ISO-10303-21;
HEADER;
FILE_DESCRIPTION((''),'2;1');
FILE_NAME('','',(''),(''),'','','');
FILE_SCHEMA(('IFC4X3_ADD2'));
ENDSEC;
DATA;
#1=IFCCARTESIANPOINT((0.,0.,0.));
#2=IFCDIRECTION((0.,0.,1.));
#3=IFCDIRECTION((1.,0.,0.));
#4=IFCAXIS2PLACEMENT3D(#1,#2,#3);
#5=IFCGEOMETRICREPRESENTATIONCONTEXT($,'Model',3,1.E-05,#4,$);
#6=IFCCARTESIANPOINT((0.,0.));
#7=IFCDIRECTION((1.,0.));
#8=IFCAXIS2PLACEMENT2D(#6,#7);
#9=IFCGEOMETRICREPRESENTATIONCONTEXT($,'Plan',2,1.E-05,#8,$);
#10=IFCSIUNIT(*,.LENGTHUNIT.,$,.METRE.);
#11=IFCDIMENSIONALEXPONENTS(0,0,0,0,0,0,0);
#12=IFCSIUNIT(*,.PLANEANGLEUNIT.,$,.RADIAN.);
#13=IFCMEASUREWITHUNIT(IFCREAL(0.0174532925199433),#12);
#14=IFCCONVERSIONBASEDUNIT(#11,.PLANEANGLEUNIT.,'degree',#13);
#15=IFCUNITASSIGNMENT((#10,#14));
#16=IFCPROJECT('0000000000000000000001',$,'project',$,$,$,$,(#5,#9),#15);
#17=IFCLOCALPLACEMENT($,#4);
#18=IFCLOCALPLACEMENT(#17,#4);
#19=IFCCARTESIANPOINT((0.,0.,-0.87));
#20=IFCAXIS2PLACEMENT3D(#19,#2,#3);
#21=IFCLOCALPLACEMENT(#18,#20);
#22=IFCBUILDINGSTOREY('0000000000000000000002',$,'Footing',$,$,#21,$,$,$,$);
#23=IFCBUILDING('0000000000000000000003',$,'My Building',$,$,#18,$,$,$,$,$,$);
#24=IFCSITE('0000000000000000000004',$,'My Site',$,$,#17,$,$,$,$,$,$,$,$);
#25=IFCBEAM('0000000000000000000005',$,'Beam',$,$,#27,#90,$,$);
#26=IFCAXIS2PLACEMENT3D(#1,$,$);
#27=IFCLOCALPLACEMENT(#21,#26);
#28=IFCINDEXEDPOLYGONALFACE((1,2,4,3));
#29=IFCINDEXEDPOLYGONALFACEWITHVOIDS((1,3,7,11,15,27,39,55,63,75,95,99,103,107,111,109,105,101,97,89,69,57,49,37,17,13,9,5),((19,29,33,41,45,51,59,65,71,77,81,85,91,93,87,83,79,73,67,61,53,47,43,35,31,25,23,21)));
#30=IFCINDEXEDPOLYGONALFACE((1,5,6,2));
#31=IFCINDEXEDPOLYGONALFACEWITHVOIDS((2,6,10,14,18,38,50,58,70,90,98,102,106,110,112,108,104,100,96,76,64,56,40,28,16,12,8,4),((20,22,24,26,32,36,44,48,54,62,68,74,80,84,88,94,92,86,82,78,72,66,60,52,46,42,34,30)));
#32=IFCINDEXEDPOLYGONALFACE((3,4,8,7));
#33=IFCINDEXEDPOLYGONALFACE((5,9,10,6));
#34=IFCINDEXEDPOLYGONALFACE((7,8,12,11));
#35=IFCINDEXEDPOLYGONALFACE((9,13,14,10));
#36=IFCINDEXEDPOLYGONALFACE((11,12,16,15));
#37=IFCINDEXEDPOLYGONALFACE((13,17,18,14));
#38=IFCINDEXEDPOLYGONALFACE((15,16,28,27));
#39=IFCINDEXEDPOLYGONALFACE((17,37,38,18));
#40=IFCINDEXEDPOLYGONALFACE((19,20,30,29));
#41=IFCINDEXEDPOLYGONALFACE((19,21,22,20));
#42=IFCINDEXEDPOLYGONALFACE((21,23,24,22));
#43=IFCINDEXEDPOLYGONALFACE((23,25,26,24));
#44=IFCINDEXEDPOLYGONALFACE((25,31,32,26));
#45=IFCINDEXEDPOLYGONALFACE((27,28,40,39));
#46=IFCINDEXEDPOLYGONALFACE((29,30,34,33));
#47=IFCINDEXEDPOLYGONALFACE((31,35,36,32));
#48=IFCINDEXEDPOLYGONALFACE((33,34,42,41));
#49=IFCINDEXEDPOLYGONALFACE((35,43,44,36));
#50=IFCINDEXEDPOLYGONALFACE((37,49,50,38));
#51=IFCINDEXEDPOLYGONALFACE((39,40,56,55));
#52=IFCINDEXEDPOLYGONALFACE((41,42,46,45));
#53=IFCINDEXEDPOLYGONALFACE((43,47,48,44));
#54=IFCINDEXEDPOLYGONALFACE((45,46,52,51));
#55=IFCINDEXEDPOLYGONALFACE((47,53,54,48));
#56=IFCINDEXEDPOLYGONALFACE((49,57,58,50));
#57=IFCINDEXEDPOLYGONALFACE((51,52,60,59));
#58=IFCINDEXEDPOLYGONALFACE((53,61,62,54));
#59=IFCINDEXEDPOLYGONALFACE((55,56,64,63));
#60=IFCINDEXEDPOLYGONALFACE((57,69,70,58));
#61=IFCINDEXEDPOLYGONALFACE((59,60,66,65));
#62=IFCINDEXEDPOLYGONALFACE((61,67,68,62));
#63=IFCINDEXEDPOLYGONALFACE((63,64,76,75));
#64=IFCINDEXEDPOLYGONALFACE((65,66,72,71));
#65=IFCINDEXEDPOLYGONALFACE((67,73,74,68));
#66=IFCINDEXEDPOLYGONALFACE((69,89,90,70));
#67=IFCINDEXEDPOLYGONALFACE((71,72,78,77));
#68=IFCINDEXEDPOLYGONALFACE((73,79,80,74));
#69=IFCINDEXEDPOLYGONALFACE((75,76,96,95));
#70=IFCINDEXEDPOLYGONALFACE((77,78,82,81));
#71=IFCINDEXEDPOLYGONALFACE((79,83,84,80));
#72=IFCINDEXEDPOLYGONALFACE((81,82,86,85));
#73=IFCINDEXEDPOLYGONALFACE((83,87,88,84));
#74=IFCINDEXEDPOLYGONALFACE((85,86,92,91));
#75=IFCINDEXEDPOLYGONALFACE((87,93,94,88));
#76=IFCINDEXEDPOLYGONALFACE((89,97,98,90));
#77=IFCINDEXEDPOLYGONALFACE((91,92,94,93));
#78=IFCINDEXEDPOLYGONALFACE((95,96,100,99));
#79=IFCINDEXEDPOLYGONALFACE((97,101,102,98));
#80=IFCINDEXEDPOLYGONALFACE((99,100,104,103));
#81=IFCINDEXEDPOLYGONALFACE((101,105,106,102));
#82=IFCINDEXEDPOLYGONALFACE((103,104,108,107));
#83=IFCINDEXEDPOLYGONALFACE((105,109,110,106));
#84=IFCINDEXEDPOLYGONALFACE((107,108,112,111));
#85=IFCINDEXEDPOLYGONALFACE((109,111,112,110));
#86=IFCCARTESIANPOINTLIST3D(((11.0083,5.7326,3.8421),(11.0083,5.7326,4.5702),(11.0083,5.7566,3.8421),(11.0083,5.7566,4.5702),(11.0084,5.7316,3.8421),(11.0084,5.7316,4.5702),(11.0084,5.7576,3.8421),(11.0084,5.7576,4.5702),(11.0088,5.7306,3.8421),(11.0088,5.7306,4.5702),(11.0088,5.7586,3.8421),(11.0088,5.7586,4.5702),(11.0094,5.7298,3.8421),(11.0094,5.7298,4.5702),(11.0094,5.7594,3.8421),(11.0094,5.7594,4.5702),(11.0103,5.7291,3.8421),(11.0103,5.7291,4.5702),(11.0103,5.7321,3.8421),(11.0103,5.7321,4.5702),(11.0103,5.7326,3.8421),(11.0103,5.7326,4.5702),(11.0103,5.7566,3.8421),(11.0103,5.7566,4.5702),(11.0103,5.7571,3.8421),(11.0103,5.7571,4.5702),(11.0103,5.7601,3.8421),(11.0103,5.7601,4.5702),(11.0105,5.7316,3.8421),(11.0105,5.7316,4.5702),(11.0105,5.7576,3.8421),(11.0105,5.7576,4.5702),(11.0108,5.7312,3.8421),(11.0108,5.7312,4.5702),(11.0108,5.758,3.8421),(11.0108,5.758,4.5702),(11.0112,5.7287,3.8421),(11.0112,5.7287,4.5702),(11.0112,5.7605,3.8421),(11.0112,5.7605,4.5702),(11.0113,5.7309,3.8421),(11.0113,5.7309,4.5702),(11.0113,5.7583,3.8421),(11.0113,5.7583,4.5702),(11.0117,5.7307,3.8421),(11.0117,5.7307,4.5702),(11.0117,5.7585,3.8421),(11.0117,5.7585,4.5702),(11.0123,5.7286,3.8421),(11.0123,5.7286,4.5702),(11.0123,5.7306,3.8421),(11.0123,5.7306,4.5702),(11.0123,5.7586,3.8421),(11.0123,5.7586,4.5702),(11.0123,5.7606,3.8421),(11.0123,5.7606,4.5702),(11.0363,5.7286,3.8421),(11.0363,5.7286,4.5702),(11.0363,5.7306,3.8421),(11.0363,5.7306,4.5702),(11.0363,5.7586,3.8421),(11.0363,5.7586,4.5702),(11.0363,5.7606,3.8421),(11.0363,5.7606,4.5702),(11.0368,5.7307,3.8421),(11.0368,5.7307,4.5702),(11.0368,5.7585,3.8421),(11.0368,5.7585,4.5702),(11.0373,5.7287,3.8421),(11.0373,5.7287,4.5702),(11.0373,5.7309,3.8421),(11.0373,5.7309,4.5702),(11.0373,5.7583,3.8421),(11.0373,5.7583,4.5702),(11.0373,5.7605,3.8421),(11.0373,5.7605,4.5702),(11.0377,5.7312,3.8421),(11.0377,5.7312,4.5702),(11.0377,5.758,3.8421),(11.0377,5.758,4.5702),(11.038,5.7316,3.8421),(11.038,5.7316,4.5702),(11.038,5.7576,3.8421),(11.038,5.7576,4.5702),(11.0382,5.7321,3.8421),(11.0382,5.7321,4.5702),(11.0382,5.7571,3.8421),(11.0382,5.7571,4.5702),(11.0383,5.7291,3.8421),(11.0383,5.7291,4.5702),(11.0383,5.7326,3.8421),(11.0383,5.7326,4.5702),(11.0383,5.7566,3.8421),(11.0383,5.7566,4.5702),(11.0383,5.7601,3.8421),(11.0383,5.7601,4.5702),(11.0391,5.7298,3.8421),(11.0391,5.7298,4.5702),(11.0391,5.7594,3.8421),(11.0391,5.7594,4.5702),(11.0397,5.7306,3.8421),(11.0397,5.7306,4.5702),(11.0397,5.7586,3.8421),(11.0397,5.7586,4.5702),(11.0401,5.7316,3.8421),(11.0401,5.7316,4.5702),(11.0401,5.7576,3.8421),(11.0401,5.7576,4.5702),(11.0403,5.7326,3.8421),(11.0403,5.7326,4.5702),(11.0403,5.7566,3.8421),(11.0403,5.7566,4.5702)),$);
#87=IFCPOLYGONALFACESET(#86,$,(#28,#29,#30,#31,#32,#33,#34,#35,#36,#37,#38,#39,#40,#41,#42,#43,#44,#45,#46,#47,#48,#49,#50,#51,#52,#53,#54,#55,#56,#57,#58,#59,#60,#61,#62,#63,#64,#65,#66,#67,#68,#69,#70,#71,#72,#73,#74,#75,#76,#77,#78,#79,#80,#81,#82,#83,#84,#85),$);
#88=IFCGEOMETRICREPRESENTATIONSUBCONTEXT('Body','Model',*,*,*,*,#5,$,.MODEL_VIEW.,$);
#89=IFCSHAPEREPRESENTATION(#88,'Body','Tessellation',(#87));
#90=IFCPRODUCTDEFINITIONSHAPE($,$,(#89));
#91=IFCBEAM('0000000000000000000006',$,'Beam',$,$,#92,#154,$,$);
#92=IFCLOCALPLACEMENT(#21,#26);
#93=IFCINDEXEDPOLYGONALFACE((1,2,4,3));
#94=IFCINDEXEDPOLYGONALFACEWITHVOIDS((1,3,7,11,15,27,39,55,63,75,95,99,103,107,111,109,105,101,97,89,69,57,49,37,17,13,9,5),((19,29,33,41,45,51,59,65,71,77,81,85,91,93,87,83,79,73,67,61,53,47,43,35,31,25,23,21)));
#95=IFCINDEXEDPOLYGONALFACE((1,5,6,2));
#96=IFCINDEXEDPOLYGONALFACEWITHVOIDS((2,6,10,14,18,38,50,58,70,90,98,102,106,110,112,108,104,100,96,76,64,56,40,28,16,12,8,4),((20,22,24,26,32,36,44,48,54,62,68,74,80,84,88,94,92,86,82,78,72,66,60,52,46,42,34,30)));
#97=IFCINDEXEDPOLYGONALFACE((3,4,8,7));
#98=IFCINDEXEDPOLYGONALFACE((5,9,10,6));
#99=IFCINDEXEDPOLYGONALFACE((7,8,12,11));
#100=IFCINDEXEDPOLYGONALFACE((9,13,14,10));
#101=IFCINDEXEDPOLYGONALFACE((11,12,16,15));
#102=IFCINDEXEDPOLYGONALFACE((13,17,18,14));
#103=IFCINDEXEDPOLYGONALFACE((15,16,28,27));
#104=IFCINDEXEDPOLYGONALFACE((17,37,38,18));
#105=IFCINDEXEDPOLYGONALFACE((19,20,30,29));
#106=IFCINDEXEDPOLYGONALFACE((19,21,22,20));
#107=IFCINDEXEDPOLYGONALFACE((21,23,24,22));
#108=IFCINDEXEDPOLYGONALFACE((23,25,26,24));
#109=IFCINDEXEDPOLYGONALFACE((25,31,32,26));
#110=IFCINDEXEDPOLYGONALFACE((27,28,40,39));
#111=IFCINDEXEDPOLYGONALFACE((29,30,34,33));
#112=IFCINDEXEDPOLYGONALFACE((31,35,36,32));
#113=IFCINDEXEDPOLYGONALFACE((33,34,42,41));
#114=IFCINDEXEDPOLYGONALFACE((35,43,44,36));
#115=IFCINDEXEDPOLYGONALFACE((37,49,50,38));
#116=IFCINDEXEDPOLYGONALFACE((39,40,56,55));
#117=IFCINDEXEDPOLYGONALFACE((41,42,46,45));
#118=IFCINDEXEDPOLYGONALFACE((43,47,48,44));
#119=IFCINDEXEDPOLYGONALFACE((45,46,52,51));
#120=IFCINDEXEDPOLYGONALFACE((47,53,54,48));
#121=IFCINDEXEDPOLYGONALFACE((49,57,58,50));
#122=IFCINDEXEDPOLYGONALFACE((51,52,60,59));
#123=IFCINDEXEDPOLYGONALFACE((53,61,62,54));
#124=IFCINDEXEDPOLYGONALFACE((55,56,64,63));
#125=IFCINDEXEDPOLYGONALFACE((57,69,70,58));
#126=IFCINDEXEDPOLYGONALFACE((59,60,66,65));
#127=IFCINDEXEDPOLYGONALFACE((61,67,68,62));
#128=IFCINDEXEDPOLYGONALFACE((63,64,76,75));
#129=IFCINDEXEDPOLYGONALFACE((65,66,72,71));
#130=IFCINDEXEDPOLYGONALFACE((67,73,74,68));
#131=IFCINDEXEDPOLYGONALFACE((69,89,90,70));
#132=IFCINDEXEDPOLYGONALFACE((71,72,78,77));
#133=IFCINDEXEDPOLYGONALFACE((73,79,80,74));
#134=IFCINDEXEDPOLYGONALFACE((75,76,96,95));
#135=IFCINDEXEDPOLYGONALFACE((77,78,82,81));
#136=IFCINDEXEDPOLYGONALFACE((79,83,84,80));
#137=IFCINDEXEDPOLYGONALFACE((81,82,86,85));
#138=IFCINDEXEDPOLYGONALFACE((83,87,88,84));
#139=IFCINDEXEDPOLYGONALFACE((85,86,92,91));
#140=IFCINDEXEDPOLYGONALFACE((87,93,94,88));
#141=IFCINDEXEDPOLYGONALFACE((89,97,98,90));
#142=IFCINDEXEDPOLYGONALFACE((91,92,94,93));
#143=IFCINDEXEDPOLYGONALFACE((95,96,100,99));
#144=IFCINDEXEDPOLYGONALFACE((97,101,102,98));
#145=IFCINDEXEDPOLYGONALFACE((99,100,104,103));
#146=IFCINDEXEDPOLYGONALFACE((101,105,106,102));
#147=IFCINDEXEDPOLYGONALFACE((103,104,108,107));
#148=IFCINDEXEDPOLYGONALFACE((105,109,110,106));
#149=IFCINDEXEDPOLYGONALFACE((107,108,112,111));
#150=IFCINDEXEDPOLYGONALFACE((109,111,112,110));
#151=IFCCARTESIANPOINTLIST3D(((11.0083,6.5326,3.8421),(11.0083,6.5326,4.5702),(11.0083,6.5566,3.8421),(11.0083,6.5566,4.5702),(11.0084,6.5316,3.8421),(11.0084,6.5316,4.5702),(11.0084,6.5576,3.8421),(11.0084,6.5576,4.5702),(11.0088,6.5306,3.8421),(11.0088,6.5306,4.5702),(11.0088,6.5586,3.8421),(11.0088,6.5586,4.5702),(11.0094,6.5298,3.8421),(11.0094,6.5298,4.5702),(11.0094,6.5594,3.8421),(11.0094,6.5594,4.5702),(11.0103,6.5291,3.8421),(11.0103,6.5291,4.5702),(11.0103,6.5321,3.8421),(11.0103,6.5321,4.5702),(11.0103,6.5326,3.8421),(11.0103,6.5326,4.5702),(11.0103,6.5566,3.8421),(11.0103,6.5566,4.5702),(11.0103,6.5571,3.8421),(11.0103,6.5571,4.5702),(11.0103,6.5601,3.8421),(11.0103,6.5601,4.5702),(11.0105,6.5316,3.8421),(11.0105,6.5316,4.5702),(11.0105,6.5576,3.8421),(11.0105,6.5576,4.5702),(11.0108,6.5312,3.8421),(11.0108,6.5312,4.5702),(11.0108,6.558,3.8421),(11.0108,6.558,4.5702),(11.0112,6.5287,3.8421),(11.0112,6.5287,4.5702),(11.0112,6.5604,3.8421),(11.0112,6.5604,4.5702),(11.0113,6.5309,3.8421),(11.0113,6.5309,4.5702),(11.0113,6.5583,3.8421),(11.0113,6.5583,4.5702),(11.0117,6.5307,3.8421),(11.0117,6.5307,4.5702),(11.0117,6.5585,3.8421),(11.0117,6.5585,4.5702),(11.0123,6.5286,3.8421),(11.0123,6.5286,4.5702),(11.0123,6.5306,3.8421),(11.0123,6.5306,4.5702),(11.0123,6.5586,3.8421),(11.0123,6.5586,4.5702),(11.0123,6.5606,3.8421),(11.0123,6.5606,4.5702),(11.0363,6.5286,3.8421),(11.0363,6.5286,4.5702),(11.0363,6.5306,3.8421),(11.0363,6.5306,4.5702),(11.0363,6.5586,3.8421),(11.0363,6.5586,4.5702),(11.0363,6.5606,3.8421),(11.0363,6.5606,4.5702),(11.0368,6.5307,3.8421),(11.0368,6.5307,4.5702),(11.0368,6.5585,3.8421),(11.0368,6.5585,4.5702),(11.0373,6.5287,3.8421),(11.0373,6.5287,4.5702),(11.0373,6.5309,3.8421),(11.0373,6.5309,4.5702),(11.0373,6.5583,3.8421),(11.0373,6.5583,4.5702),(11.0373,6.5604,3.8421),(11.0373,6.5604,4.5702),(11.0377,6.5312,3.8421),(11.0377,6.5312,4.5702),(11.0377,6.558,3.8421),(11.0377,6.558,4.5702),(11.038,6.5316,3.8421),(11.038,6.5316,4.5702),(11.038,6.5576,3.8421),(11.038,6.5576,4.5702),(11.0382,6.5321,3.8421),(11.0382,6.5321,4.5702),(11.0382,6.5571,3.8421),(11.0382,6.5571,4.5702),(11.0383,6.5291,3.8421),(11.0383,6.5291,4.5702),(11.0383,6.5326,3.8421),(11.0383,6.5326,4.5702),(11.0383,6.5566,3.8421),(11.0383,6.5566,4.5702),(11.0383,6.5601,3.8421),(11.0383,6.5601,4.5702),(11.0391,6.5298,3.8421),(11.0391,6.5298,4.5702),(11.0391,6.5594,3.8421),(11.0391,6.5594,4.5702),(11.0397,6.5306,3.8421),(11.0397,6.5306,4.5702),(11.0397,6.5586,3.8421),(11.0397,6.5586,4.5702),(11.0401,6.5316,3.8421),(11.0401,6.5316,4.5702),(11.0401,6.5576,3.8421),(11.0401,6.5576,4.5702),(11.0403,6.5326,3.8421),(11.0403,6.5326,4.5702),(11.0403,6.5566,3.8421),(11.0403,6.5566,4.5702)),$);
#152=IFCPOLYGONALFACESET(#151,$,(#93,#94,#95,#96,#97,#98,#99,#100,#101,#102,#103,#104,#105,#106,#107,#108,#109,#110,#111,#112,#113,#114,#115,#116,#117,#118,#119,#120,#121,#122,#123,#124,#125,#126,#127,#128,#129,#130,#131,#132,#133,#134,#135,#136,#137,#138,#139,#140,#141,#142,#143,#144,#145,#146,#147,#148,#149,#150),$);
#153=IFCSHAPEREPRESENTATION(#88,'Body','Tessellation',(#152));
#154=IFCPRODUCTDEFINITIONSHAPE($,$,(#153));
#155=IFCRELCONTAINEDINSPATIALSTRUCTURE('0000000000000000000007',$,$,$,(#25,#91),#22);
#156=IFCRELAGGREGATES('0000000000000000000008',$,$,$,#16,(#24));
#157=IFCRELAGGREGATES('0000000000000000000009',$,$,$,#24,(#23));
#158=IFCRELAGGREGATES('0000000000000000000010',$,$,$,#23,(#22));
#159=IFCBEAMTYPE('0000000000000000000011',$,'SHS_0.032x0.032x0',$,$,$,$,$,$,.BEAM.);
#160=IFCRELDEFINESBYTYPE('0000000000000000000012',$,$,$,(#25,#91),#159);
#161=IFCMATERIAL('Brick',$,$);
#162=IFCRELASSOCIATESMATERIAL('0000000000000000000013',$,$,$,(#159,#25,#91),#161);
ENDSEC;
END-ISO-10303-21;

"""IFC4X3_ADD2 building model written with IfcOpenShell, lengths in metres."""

from ifc_helpers import new_model, entity, si_unit, converted_unit, frame, origin_with_axes, origin_2d_with_axis, place, context, subcontext, project, spatial, hollow_rectangle, extrude, material, material_profile, profile_set, profile_usage, type_object, element, save


model = new_model("IFC4X3_ADD2")

# Units and contexts
model_context = context("Model", 3, precision=1e-05, world=origin_with_axes())
plan_context = context("Plan", 2, precision=1e-05, world=origin_2d_with_axis())
body_context = subcontext(model_context, "Body", "Model", "MODEL_VIEW")
ifc_project = project(units=[si_unit("LENGTHUNIT", "METRE"), converted_unit("PLANEANGLEUNIT", "degree", entity("IfcReal", 0.0174532925199433), si_unit("PLANEANGLEUNIT", "RADIAN"), dimensions=[0, 0, 0, 0, 0, 0, 0])], contexts=[model_context, plan_context])

# Site, building, storey
site_placement = place(None, origin_with_axes())
site = spatial("IfcSite", under=ifc_project, at=site_placement, Name="My Site")
building_placement = place(site_placement, origin_with_axes())
building = spatial("IfcBuilding", under=site, at=building_placement, Name="My Building")
storey_placement = place(building_placement, frame((0.0, 0.0, -0.87), z_axis=(0.0, 0.0, 1.0), x_axis=(1.0, 0.0, 0.0)))
storey = spatial("IfcBuildingStorey", under=building, at=storey_placement, Name="Footing")

# Beams
ifc_material_1 = material(Name="Brick")
ifc_material_profile = material_profile(ifc_material_1, hollow_rectangle(XDim=0.032, YDim=0.032, WallThickness=0.002, InnerFilletRadius=0.002, OuterFilletRadius=0.004))
ifc_profile_set = profile_set([ifc_material_profile])
beam_type_1 = type_object("IfcBeamType", Name="SHS_0.032x0.032x0", PredefinedType="BEAM", material=ifc_profile_set)
ifc_profile_usage_1 = profile_usage(ifc_profile_set, cardinal=5)
beam_1_placement = place(storey_placement, frame((11.0243, 5.7446, 3.8421), z_axis=(0.0, 0.0, 1.0), x_axis=(1.0, 0.0, 0.0)))
element("IfcBeam", 1, at=beam_1_placement, inside=storey, type_object=beam_type_1, material=ifc_profile_usage_1, Name="Beam", context=body_context, shape_type="SweptSolid", body=[
    extrude(hollow_rectangle(XDim=0.032, YDim=0.032, WallThickness=0.002, InnerFilletRadius=0.002, OuterFilletRadius=0.004), origin_with_axes(), (0.0, 0.0, 1.0), 0.7281),
])
ifc_profile_usage_2 = profile_usage(ifc_profile_set, cardinal=5)
beam_2_placement = place(storey_placement, frame((11.0243, 6.5446, 3.8421), z_axis=(0.0, 0.0, 1.0), x_axis=(1.0, 0.0, 0.0)))
element("IfcBeam", 2, at=beam_2_placement, inside=storey, type_object=beam_type_1, material=ifc_profile_usage_2, Name="Beam", context=body_context, shape_type="SweptSolid", body=[
    extrude(hollow_rectangle(XDim=0.032, YDim=0.032, WallThickness=0.002, InnerFilletRadius=0.002, OuterFilletRadius=0.004), origin_with_axes(), (0.0, 0.0, 1.0), 0.7281),
])

save(model, "model.ifc")
